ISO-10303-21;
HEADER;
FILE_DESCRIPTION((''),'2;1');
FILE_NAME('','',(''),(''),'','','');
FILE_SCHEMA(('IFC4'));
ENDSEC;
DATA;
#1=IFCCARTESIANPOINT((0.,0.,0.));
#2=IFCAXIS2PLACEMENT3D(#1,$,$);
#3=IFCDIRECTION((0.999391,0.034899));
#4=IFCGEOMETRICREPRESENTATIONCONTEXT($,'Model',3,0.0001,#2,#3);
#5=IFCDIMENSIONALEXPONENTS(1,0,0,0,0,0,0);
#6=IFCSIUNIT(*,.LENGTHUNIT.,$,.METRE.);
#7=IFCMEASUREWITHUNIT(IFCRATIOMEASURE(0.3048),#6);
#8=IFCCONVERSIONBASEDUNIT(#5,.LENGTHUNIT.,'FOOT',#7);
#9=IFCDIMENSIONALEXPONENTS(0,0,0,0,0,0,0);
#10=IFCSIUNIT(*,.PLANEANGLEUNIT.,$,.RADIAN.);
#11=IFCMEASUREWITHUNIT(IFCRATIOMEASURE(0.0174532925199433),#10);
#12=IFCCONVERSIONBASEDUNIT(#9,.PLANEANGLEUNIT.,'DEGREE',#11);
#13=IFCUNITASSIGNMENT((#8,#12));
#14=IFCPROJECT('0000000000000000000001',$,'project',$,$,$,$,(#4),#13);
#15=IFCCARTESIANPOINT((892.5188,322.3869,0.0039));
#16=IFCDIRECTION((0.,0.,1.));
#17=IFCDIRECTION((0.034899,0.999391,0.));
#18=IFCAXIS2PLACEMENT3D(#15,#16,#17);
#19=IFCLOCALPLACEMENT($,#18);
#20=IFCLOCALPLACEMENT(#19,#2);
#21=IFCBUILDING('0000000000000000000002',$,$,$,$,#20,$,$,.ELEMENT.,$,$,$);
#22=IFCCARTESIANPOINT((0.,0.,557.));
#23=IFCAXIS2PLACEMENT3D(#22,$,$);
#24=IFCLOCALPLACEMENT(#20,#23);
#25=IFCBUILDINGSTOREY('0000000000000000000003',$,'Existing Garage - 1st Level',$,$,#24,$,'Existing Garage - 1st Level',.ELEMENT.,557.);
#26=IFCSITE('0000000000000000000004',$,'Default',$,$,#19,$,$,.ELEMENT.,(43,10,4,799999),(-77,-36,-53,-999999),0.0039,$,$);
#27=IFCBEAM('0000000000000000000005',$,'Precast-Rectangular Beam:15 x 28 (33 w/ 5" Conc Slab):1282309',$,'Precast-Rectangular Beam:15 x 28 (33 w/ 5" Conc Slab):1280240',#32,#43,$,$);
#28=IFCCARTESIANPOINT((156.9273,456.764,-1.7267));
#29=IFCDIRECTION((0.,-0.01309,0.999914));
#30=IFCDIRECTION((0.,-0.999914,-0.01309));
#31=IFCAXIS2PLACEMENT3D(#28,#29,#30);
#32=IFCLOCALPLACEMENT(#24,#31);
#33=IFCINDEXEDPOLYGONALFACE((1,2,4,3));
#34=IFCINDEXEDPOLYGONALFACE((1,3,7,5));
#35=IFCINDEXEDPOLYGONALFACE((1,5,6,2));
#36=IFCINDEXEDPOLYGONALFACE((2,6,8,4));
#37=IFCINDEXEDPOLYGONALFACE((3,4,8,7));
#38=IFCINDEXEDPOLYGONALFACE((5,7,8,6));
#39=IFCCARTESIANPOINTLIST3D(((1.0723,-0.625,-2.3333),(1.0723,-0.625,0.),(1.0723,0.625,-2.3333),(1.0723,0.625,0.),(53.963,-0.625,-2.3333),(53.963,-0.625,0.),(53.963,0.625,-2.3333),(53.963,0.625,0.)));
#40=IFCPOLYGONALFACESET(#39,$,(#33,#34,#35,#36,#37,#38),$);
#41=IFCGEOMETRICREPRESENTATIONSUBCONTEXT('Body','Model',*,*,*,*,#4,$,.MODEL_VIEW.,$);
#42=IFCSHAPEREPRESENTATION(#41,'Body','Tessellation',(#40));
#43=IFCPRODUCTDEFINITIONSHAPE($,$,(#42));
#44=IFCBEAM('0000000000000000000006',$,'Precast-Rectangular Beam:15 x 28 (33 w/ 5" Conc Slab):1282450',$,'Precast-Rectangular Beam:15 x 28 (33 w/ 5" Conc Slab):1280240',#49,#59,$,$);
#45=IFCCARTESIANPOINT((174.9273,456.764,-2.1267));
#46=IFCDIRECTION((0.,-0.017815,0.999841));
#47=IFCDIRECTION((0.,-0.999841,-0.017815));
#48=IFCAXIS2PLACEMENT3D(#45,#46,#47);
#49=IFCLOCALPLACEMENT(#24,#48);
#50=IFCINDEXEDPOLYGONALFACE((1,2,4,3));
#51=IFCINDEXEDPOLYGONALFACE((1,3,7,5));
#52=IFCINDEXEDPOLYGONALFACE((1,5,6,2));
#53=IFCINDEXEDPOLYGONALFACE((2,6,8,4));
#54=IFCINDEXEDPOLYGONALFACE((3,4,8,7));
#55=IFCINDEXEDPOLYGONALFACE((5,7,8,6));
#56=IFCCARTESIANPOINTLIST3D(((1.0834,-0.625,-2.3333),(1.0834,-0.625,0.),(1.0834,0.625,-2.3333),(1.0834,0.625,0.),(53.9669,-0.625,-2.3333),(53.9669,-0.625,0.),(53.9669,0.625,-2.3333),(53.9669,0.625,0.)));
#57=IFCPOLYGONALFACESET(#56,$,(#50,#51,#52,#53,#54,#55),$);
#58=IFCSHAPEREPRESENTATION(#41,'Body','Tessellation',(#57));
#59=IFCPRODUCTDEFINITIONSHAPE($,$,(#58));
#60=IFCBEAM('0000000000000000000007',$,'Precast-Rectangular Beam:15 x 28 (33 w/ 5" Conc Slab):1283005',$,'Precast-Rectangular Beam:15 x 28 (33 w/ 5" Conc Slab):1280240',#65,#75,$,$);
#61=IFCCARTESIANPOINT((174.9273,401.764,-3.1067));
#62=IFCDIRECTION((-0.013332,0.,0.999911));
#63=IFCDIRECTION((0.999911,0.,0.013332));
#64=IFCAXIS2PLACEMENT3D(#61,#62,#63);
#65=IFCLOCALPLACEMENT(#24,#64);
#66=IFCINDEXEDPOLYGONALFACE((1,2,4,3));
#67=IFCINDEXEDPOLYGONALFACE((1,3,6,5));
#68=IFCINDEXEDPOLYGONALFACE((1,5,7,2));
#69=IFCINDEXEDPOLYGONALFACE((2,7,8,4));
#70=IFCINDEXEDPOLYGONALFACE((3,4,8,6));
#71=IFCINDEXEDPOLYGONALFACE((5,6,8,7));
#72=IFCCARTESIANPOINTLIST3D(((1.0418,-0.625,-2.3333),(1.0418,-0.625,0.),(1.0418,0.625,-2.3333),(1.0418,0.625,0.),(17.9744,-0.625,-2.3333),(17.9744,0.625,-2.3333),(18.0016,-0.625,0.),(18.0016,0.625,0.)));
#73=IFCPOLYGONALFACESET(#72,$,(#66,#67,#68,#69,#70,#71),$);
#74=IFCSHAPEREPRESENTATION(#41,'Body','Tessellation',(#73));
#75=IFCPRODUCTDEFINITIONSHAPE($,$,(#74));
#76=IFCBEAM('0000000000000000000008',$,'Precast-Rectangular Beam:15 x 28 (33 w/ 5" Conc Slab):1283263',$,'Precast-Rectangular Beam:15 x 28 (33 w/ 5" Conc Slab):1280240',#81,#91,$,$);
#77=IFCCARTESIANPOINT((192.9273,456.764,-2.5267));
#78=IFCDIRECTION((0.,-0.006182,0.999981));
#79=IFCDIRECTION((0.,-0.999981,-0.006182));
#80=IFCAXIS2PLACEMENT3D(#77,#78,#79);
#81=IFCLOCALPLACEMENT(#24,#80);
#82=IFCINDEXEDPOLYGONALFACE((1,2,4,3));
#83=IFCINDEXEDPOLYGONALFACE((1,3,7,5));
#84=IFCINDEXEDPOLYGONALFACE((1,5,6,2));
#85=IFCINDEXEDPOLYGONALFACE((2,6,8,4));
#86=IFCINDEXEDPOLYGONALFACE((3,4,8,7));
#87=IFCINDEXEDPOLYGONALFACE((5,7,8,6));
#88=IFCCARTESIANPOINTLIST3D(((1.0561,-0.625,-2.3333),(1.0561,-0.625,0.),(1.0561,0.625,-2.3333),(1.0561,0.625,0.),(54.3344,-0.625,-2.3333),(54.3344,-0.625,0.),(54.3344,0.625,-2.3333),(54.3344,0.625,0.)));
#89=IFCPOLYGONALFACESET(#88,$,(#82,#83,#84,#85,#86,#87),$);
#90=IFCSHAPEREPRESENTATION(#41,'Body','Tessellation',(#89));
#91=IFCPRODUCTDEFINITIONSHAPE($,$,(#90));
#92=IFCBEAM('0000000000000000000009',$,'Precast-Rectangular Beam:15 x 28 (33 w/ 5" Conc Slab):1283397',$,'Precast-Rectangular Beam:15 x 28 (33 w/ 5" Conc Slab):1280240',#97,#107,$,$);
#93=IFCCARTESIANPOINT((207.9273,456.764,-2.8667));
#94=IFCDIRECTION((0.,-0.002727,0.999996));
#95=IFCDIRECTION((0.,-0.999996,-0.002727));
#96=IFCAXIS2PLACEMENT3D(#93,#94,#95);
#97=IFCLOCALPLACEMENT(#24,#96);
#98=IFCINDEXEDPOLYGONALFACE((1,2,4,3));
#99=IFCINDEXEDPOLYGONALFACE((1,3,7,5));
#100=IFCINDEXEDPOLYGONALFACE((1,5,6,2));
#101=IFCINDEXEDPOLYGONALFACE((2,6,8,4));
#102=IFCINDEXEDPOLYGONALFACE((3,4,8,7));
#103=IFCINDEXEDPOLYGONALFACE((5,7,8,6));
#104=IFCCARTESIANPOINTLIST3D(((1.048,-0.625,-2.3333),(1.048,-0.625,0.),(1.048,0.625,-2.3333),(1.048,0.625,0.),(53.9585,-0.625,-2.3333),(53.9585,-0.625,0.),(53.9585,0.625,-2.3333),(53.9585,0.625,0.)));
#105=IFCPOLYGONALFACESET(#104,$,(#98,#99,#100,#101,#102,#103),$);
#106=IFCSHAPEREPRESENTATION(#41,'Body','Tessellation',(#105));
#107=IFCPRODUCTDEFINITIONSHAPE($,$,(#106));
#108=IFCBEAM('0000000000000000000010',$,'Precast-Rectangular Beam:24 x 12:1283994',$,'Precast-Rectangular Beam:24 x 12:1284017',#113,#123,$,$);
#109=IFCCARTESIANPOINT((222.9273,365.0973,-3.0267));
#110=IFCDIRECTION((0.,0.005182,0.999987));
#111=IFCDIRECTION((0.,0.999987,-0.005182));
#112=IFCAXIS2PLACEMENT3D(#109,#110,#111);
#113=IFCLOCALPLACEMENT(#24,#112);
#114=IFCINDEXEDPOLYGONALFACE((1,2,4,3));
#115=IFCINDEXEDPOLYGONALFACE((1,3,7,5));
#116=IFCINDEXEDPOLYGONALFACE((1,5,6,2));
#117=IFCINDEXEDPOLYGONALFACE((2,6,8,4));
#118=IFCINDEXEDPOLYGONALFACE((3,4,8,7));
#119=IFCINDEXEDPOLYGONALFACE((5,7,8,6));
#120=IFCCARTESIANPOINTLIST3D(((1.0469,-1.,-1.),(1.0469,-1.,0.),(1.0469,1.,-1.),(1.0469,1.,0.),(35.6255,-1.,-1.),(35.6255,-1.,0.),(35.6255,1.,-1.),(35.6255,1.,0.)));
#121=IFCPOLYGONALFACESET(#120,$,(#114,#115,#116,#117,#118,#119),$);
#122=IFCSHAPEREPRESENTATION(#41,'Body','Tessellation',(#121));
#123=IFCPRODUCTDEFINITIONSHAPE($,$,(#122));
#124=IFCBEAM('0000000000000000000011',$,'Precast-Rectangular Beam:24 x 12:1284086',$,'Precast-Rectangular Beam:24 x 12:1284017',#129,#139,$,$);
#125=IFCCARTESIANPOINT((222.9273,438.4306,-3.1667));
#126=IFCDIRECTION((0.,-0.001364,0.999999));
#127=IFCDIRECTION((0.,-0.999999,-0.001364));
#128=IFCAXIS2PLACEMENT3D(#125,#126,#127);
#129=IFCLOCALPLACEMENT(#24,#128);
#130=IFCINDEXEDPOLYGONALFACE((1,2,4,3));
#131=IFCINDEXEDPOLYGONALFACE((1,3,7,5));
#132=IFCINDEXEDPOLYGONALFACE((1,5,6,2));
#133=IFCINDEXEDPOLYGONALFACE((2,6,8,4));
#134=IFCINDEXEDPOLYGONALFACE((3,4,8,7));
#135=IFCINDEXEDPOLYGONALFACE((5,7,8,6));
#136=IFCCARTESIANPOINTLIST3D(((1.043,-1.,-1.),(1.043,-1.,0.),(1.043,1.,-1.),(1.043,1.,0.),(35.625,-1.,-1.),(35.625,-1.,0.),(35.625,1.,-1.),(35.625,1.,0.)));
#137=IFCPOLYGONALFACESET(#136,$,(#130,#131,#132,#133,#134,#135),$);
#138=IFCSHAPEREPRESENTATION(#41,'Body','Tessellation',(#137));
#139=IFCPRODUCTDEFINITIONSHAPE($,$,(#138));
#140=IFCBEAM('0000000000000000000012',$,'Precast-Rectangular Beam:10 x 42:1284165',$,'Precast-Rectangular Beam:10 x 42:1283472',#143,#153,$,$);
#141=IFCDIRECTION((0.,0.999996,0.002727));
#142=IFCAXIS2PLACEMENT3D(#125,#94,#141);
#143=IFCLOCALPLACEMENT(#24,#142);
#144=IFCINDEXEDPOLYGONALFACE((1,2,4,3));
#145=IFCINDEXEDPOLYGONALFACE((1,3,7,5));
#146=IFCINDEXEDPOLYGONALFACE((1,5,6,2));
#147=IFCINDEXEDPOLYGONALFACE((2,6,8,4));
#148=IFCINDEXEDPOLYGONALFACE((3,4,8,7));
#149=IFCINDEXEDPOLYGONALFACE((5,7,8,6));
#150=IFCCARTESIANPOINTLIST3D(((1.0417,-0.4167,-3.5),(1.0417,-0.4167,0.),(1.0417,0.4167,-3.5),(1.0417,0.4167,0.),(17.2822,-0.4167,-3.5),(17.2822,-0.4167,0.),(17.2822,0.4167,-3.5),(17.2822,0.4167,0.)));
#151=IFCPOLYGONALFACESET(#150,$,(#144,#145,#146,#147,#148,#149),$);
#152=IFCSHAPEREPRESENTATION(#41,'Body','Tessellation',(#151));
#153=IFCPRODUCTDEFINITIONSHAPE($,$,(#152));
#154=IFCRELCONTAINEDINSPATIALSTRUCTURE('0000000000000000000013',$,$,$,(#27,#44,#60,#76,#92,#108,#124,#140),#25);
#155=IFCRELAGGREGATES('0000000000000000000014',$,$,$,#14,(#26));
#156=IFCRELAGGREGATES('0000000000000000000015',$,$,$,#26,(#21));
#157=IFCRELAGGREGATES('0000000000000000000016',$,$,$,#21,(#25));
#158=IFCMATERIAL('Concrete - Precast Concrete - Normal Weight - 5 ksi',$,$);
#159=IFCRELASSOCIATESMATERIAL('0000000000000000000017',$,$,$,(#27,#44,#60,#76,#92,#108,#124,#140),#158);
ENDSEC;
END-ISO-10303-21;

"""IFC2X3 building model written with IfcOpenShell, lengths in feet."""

from ifc_helpers import new_model, entity, si_unit, converted_unit, direction, frame, frame_2d, origin, origin_2d_with_axis, place, context, subcontext, project, spatial, rectangle, extrude, clip, halfspace, material, element, save


model = new_model("IFC2X3")

# Units and contexts
model_context = context("Model", 3, precision=0.0001, world=origin(), true_north=direction((0.999391, 0.034899)))
body_context = subcontext(model_context, "Body", "Model", "MODEL_VIEW")
ifc_project = project(units=[converted_unit("LENGTHUNIT", "FOOT", entity("IfcRatioMeasure", 0.3048), si_unit("LENGTHUNIT", "METRE"), dimensions=[1, 0, 0, 0, 0, 0, 0]), converted_unit("PLANEANGLEUNIT", "DEGREE", entity("IfcRatioMeasure", 0.0174532925199433), si_unit("PLANEANGLEUNIT", "RADIAN"), dimensions=[0, 0, 0, 0, 0, 0, 0])], contexts=[model_context])

# Site, building, storey
site_placement = place(None, frame((892.5188, 322.3869, 0.0039), z_axis=(0.0, 0.0, 1.0), x_axis=(0.034899, 0.999391, 0.0)))
site = spatial("IfcSite", under=ifc_project, at=site_placement, Name="Default", CompositionType="ELEMENT", RefLatitude=(43, 10, 4, 799999), RefLongitude=(-77, -36, -53, -999999), RefElevation=0.0039)
building_placement = place(site_placement, origin())
building = spatial("IfcBuilding", under=site, at=building_placement, CompositionType="ELEMENT")
storey_placement = place(building_placement, frame((0.0, 0.0, 557.0)))
storey = spatial("IfcBuildingStorey", under=building, at=storey_placement, Name="Existing Garage - 1st Level", LongName="Existing Garage - 1st Level", CompositionType="ELEMENT", Elevation=557.0)

# Beams
ifc_material_1 = material(Name="Concrete - Precast Concrete - Normal Weight - 5 ksi")
beam_1_placement = place(storey_placement, frame((156.9273, 456.764, -1.7267), z_axis=(0.0, -0.01309, 0.999914), x_axis=(0.0, -0.999914, -0.01309)))
element("IfcBeam", 1, at=beam_1_placement, inside=storey, material=ifc_material_1, Name="Precast-Rectangular Beam:15 x 28 (33 w/ 5\" Conc Slab):1282309", ObjectType="Precast-Rectangular Beam:15 x 28 (33 w/ 5\" Conc Slab):1280240", context=body_context, shape_type="SweptSolid", body=[
    extrude(rectangle(XDim=2.3333, YDim=1.25, at=frame_2d((0.0, 0.0), x_axis=(1.0, 0.0))), frame((1.0723, 0.0, -1.1667), z_axis=(1.0, 0.0, 0.0), x_axis=(0.0, 0.0, -1.0)), (0.0, 0.0, 1.0), 52.8907),
])
beam_2_placement = place(storey_placement, frame((174.9273, 456.764, -2.1267), z_axis=(0.0, -0.017815, 0.999841), x_axis=(0.0, -0.999841, -0.017815)))
element("IfcBeam", 2, at=beam_2_placement, inside=storey, material=ifc_material_1, Name="Precast-Rectangular Beam:15 x 28 (33 w/ 5\" Conc Slab):1282450", ObjectType="Precast-Rectangular Beam:15 x 28 (33 w/ 5\" Conc Slab):1280240", context=body_context, shape_type="SweptSolid", body=[
    extrude(rectangle(XDim=2.3333, YDim=1.25, at=frame_2d((0.0, 0.0), x_axis=(1.0, 0.0))), frame((1.0834, 0.0, -1.1667), z_axis=(1.0, 0.0, 0.0), x_axis=(0.0, 0.0, -1.0)), (0.0, 0.0, 1.0), 52.8835),
])
beam_3_placement = place(storey_placement, frame((174.9273, 401.764, -3.1067), z_axis=(-0.013332, 0.0, 0.999911), x_axis=(0.999911, 0.0, 0.013332)))
element("IfcBeam", 3, at=beam_3_placement, inside=storey, material=ifc_material_1, Name="Precast-Rectangular Beam:15 x 28 (33 w/ 5\" Conc Slab):1283005", ObjectType="Precast-Rectangular Beam:15 x 28 (33 w/ 5\" Conc Slab):1280240", context=body_context, shape_type="Clipping", body=[
    clip(extrude(rectangle(XDim=2.3333, YDim=1.25, at=origin_2d_with_axis()), frame((1.0418, 0.0, -1.1667), z_axis=(1.0, 0.0, 0.0), x_axis=(0.0, 0.0, -1.0)), (0.0, 0.0, 1.0), 16.9598), halfspace(frame((18.0016, 0.0, 0.0), z_axis=(0.999932, 0.0, -0.011666), x_axis=(0.0, 1.0, 0.0)), False)),
])
beam_4_placement = place(storey_placement, frame((192.9273, 456.764, -2.5267), z_axis=(0.0, -0.006182, 0.999981), x_axis=(0.0, -0.999981, -0.006182)))
element("IfcBeam", 4, at=beam_4_placement, inside=storey, material=ifc_material_1, Name="Precast-Rectangular Beam:15 x 28 (33 w/ 5\" Conc Slab):1283263", ObjectType="Precast-Rectangular Beam:15 x 28 (33 w/ 5\" Conc Slab):1280240", context=body_context, shape_type="SweptSolid", body=[
    extrude(rectangle(XDim=2.3333, YDim=1.25, at=frame_2d((0.0, 0.0), x_axis=(1.0, 0.0))), frame((1.0561, 0.0, -1.1667), z_axis=(1.0, 0.0, 0.0), x_axis=(0.0, 0.0, -1.0)), (0.0, 0.0, 1.0), 53.2783),
])
beam_5_placement = place(storey_placement, frame((207.9273, 456.764, -2.8667), z_axis=(0.0, -0.002727, 0.999996), x_axis=(0.0, -0.999996, -0.002727)))
element("IfcBeam", 5, at=beam_5_placement, inside=storey, material=ifc_material_1, Name="Precast-Rectangular Beam:15 x 28 (33 w/ 5\" Conc Slab):1283397", ObjectType="Precast-Rectangular Beam:15 x 28 (33 w/ 5\" Conc Slab):1280240", context=body_context, shape_type="SweptSolid", body=[
    extrude(rectangle(XDim=2.3333, YDim=1.25, at=frame_2d((0.0, 0.0), x_axis=(1.0, 0.0))), frame((1.048, 0.0, -1.1667), z_axis=(1.0, 0.0, 0.0), x_axis=(0.0, 0.0, -1.0)), (0.0, 0.0, 1.0), 52.9105),
])
beam_6_placement = place(storey_placement, frame((222.9273, 365.0973, -3.0267), z_axis=(0.0, 0.005182, 0.999987), x_axis=(0.0, 0.999987, -0.005182)))
element("IfcBeam", 6, at=beam_6_placement, inside=storey, material=ifc_material_1, Name="Precast-Rectangular Beam:24 x 12:1283994", ObjectType="Precast-Rectangular Beam:24 x 12:1284017", context=body_context, shape_type="SweptSolid", body=[
    extrude(rectangle(XDim=1.0, YDim=2.0, at=frame_2d((0.0, 0.0), x_axis=(1.0, 0.0))), frame((1.0469, 0.0, -0.5), z_axis=(1.0, 0.0, 0.0), x_axis=(0.0, 0.0, -1.0)), (0.0, 0.0, 1.0), 34.5786),
])
beam_7_placement = place(storey_placement, frame((222.9273, 438.4306, -3.1667), z_axis=(0.0, -0.001364, 0.999999), x_axis=(0.0, -0.999999, -0.001364)))
element("IfcBeam", 7, at=beam_7_placement, inside=storey, material=ifc_material_1, Name="Precast-Rectangular Beam:24 x 12:1284086", ObjectType="Precast-Rectangular Beam:24 x 12:1284017", context=body_context, shape_type="SweptSolid", body=[
    extrude(rectangle(XDim=1.0, YDim=2.0, at=frame_2d((0.0, 0.0), x_axis=(1.0, 0.0))), frame((1.043, 0.0, -0.5), z_axis=(1.0, 0.0, 0.0), x_axis=(0.0, 0.0, -1.0)), (0.0, 0.0, 1.0), 34.582),
])
beam_8_placement = place(storey_placement, frame((222.9273, 438.4306, -3.1667), z_axis=(0.0, -0.002727, 0.999996), x_axis=(0.0, 0.999996, 0.002727)))
element("IfcBeam", 8, at=beam_8_placement, inside=storey, material=ifc_material_1, Name="Precast-Rectangular Beam:10 x 42:1284165", ObjectType="Precast-Rectangular Beam:10 x 42:1283472", context=body_context, shape_type="SweptSolid", body=[
    extrude(rectangle(XDim=3.5, YDim=0.8333, at=frame_2d((0.0, 0.0), x_axis=(1.0, 0.0))), frame((1.0417, 0.0, -1.75), z_axis=(1.0, 0.0, 0.0), x_axis=(0.0, 0.0, -1.0)), (0.0, 0.0, 1.0), 16.2405),
])

save(model, "model.ifc")
